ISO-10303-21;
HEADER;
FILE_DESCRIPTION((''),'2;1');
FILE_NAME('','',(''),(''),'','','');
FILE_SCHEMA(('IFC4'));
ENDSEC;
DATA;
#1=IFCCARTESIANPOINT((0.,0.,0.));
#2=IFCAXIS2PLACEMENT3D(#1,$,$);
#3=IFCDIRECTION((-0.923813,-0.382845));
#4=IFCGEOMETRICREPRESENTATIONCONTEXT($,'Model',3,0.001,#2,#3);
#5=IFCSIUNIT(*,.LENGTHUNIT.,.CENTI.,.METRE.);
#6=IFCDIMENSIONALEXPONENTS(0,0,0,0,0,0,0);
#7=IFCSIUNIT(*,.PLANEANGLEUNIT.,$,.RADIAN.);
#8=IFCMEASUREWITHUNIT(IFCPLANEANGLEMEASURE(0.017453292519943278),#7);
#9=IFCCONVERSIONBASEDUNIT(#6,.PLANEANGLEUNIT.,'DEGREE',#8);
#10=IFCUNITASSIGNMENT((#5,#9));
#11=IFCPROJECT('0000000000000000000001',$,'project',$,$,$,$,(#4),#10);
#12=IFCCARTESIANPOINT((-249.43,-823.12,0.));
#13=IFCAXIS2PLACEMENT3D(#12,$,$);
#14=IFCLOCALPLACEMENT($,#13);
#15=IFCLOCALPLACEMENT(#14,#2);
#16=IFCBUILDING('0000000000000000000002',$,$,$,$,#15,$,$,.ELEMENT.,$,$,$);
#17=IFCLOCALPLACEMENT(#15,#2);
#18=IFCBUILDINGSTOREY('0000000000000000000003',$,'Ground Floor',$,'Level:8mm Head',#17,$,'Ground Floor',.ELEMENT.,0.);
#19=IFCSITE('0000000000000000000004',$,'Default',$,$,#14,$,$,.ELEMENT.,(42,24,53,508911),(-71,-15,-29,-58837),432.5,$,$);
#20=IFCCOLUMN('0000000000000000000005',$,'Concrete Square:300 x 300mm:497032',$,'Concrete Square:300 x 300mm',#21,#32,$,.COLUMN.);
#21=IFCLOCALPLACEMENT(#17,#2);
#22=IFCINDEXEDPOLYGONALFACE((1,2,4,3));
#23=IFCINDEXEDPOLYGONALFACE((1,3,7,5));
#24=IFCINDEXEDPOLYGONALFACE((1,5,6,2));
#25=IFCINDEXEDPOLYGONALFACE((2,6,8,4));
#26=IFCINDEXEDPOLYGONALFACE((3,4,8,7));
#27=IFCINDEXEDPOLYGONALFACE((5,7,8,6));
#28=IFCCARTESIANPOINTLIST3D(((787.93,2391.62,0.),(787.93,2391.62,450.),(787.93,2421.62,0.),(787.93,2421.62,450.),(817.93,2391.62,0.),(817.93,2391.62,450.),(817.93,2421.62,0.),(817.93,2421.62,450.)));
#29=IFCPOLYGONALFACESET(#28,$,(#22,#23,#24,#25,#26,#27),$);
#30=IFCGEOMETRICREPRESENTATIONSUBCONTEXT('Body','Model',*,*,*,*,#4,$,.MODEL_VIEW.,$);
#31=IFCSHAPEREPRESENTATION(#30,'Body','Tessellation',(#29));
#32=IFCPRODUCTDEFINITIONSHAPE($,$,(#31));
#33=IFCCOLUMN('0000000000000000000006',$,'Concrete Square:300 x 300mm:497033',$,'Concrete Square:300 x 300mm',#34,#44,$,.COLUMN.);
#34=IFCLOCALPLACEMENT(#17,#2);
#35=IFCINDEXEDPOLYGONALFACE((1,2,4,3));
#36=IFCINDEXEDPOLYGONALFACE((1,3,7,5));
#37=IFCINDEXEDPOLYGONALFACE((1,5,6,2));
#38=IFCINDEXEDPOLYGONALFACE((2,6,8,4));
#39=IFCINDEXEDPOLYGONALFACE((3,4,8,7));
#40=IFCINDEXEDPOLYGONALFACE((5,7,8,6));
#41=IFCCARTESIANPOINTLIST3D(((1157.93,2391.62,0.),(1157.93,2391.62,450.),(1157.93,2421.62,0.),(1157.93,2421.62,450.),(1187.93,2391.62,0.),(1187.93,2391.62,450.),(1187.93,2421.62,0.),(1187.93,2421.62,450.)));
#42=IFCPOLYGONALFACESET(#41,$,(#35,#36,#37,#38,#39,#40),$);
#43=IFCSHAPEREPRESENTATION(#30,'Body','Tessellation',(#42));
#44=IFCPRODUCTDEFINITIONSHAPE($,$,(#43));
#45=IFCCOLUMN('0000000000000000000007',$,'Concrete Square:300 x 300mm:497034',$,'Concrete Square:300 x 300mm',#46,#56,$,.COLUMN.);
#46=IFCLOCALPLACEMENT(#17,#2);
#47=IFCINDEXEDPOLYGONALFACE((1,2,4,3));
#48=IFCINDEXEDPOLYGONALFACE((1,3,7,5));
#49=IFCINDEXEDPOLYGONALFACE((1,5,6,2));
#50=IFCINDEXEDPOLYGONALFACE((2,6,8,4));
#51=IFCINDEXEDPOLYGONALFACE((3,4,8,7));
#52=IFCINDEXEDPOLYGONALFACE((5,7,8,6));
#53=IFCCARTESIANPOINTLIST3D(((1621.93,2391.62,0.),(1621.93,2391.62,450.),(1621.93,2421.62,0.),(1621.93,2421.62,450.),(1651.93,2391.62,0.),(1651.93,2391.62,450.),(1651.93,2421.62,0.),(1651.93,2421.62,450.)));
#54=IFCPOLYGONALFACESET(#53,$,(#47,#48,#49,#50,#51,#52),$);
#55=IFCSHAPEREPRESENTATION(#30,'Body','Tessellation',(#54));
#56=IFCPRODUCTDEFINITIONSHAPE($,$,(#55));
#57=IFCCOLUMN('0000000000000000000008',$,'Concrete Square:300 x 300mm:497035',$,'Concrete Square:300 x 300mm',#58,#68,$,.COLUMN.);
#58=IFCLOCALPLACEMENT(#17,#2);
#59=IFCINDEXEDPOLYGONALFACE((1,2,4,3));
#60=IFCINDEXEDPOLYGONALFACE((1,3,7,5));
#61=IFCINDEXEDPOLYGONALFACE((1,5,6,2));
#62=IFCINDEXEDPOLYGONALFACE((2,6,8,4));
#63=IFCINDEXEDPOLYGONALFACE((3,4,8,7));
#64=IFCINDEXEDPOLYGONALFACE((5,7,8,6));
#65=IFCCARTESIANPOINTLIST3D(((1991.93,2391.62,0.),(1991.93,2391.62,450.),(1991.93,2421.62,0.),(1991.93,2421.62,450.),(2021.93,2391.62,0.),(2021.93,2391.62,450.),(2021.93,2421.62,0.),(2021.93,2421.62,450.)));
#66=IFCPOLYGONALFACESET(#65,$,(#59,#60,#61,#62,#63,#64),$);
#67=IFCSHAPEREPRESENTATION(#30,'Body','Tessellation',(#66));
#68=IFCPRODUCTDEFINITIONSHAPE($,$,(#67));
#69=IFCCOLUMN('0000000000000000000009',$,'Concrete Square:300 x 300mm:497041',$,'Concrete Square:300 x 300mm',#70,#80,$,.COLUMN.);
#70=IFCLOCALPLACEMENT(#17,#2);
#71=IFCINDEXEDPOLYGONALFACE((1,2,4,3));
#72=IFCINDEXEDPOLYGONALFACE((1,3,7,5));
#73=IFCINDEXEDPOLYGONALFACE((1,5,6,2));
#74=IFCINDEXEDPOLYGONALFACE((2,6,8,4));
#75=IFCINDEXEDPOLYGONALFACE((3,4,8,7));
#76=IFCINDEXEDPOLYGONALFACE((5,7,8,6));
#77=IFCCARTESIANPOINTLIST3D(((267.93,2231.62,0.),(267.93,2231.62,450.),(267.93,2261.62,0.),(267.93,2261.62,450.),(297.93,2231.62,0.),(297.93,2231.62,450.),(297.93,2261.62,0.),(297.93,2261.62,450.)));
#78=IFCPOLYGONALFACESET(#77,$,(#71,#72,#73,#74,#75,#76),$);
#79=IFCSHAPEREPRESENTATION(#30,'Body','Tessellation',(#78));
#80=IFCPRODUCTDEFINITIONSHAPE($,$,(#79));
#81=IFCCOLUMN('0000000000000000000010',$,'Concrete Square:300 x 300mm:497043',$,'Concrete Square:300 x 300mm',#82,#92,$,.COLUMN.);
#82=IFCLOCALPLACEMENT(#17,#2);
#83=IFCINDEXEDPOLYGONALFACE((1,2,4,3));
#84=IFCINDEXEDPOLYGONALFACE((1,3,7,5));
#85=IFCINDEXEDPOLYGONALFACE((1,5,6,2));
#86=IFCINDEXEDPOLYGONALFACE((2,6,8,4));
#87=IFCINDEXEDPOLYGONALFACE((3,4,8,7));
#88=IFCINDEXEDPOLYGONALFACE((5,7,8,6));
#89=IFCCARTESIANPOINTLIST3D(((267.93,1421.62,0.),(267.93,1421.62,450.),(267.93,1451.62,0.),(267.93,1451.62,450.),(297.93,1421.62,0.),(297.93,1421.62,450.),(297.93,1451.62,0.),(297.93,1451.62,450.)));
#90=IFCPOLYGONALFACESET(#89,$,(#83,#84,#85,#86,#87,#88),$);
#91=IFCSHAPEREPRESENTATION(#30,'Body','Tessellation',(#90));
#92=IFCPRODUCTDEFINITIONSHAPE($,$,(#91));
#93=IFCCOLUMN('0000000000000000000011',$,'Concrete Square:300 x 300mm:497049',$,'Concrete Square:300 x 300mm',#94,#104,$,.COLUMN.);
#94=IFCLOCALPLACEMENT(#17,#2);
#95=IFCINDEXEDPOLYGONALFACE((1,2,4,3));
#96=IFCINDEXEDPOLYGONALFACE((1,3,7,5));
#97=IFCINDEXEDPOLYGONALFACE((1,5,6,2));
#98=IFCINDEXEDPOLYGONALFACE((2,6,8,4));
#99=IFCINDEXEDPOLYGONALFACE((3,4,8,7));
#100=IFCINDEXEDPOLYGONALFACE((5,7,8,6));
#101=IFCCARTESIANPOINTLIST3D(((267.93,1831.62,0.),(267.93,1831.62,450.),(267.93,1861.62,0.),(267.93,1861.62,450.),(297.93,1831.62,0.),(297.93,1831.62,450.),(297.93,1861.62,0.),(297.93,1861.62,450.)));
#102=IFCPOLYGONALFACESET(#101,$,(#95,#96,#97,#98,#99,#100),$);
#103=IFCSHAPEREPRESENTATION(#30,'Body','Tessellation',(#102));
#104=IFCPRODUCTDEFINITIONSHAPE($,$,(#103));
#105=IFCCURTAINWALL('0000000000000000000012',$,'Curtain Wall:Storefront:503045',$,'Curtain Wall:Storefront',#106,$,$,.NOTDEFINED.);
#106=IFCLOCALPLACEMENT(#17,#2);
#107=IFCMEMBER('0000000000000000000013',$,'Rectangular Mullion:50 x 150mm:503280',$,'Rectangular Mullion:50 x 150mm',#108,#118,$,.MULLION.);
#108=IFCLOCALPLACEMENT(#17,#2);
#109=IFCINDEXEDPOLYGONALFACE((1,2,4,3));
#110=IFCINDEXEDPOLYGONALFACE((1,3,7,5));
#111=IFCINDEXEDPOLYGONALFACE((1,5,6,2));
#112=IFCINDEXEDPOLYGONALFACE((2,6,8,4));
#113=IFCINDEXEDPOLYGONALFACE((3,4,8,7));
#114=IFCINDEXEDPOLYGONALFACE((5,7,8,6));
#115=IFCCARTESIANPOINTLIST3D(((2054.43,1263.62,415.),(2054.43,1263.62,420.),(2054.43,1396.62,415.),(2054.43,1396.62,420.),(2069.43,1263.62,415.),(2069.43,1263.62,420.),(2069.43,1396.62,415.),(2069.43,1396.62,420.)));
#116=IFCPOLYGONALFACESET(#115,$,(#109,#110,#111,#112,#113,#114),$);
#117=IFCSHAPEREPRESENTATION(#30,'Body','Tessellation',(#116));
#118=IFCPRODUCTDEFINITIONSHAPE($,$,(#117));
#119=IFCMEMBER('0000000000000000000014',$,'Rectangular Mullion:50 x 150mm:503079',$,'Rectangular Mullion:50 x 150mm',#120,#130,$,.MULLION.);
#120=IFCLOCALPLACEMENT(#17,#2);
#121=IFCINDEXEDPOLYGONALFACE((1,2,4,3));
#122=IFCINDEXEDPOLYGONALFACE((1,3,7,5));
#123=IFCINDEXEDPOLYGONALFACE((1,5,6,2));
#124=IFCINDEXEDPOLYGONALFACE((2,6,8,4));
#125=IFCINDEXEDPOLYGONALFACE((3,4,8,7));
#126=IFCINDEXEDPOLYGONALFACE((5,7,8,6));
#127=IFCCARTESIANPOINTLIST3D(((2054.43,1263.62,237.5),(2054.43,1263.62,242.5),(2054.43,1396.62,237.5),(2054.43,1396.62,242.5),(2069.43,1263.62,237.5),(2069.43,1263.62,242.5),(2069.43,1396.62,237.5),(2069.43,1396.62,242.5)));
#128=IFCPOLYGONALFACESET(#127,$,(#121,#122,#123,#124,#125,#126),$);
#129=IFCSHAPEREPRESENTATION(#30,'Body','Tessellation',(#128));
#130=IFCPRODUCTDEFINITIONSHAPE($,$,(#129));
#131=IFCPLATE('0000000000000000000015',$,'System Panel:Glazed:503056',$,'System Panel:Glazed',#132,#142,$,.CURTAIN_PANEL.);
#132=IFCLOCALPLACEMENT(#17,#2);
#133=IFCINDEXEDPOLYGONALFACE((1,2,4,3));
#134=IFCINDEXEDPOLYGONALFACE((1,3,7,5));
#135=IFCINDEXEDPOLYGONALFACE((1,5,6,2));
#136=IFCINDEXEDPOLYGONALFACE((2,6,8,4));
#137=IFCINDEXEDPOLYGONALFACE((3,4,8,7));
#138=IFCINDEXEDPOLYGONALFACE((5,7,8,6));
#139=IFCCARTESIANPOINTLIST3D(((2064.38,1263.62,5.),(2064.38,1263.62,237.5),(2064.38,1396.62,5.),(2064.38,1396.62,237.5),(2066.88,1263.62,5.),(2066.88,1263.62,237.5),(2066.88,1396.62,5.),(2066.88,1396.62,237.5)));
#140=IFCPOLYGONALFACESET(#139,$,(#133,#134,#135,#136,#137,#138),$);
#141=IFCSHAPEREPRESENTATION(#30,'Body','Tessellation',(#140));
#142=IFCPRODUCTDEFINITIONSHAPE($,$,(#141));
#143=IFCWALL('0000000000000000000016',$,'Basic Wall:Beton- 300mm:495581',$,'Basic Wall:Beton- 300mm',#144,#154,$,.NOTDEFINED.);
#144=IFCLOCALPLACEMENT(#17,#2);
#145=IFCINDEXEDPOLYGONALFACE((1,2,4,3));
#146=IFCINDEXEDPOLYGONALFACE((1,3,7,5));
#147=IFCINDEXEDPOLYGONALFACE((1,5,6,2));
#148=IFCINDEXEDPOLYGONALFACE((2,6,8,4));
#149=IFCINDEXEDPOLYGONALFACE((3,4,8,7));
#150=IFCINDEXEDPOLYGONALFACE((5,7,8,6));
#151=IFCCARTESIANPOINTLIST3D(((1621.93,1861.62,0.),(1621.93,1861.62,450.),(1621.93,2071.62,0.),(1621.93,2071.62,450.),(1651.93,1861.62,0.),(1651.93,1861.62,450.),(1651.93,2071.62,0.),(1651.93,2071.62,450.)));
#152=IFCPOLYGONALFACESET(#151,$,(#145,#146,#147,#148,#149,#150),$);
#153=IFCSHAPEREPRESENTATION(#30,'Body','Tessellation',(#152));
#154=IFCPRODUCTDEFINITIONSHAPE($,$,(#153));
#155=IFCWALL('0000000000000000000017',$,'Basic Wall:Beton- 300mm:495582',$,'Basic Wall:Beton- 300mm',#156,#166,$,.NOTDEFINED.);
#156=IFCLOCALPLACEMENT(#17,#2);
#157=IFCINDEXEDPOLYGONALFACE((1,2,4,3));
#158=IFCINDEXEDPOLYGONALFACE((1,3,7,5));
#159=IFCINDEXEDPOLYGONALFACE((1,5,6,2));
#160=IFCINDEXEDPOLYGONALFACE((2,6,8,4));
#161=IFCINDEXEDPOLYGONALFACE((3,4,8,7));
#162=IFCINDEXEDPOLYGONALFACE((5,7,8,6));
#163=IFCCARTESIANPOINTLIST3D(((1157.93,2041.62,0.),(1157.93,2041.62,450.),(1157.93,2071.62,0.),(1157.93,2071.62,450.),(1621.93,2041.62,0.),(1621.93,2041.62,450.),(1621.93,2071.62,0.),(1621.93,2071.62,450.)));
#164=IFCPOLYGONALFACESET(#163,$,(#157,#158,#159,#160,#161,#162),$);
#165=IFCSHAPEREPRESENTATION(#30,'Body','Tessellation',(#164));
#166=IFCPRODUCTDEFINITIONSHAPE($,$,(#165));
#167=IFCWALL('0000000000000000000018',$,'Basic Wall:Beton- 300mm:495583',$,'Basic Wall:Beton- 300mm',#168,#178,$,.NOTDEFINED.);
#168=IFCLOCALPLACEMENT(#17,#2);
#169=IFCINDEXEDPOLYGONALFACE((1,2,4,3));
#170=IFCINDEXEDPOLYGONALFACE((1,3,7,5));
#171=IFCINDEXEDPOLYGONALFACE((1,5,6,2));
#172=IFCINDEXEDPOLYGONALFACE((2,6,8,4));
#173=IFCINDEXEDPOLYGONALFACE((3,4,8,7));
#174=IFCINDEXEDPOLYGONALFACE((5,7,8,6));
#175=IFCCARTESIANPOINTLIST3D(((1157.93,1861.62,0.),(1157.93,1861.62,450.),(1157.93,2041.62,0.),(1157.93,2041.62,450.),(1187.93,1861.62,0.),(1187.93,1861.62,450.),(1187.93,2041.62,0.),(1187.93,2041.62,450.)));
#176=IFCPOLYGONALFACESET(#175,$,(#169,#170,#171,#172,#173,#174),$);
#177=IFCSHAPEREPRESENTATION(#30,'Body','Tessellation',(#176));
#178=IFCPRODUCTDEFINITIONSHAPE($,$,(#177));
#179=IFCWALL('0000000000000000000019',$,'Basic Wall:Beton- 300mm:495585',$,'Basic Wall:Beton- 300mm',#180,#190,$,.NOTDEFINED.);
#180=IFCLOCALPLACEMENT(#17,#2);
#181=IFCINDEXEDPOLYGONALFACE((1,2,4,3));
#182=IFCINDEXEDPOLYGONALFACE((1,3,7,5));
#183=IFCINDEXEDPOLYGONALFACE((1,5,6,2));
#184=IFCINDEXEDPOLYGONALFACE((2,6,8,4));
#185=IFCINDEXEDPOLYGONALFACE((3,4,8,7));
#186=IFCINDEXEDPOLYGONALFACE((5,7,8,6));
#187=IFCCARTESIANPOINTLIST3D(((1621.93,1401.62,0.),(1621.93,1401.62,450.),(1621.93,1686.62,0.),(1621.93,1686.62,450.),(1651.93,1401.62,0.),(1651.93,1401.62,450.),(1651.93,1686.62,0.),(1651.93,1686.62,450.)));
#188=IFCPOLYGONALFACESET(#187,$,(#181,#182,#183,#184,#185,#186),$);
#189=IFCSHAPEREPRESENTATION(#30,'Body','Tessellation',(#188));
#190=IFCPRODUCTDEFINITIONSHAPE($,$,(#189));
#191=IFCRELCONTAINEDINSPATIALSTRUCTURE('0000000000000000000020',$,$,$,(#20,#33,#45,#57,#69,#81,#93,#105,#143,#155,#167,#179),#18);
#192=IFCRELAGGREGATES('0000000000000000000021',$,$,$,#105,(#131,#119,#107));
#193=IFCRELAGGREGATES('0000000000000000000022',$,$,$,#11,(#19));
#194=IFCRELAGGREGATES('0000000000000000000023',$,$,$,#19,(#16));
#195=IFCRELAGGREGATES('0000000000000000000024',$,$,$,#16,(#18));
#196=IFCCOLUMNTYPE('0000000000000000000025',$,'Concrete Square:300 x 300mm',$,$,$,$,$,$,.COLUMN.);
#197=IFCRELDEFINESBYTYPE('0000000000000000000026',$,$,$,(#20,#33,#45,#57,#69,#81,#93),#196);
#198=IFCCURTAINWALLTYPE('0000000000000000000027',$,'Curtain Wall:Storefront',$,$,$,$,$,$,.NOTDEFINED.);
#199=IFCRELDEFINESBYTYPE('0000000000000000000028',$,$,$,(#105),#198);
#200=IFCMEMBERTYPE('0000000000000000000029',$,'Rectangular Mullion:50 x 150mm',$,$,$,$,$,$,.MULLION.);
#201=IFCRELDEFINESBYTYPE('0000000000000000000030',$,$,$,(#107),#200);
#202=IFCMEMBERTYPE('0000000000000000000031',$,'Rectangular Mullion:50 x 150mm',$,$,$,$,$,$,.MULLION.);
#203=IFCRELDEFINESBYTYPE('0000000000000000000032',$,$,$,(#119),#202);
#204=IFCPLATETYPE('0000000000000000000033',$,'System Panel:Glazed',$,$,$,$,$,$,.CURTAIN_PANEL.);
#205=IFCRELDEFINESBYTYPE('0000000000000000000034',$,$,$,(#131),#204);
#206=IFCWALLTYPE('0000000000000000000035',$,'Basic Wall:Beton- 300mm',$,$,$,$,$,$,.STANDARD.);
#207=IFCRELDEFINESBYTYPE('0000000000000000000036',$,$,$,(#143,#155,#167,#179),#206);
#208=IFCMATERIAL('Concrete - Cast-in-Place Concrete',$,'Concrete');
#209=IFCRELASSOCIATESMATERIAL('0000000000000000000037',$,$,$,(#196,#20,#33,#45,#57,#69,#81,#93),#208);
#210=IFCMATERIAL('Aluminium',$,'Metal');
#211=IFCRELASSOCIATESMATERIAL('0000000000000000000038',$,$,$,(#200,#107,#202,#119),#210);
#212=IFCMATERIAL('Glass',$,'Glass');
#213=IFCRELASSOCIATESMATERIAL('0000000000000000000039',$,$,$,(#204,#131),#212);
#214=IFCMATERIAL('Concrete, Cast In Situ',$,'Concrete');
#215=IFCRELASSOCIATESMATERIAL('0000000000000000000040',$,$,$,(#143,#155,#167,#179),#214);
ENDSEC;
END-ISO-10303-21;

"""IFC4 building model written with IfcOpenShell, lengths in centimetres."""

from ifc_helpers import new_model, entity, si_unit, converted_unit, direction, frame, origin, place, context, subcontext, project, spatial, indexed_curve, outline, extrude, source, transform, mapped, material, type_object, type_shapes, element, aggregate, save


model = new_model("IFC4")

# Units and contexts
model_context = context("Model", 3, precision=0.001, world=origin(), true_north=direction((-0.923813, -0.382845)))
body_context = subcontext(model_context, "Body", "Model", "MODEL_VIEW")
ifc_project = project(units=[si_unit("LENGTHUNIT", "METRE", prefix="CENTI"), converted_unit("PLANEANGLEUNIT", "DEGREE", entity("IfcPlaneAngleMeasure", 0.017453292519943278), si_unit("PLANEANGLEUNIT", "RADIAN"), dimensions=[0, 0, 0, 0, 0, 0, 0])], contexts=[model_context])

# Site, building, storey
site_placement = place(None, frame((-249.43, -823.12, 0.0)))
site = spatial("IfcSite", under=ifc_project, at=site_placement, Name="Default", CompositionType="ELEMENT", RefLatitude=(42, 24, 53, 508911), RefLongitude=(-71, -15, -29, -58837), RefElevation=432.5)
building_placement = place(site_placement, origin())
building = spatial("IfcBuilding", under=site, at=building_placement, CompositionType="ELEMENT")
storey_placement = place(building_placement, origin())
storey = spatial("IfcBuildingStorey", under=building, at=storey_placement, Name="Ground Floor", ObjectType="Level:8mm Head", LongName="Ground Floor", CompositionType="ELEMENT", Elevation=0.0)

# Columns
ifc_material_1 = material(Name="Concrete - Cast-in-Place Concrete", Category="Concrete")
column_type = type_object("IfcColumnType", Name="Concrete Square:300 x 300mm", PredefinedType="COLUMN", material=ifc_material_1)
shared_shape_1 = source(origin(), body_context, "Body", "SweptSolid", [
    extrude(outline(indexed_curve([(-15.0, -15.0), (15.0, -15.0), (15.0, 15.0), (-15.0, 15.0), (-15.0, -15.0)], self_intersect=False)), frame((0.0, 0.0, 0.0), z_axis=(0.0, 0.0, 1.0), x_axis=(-1.0, 0.0, 0.0)), (0.0, 0.0, 1.0), 450.0),
])
type_shapes(column_type, [shared_shape_1])
for number, where, name in (
    (1, (802.93, 2406.62, 0.0), "Concrete Square:300 x 300mm:497032"),
    (2, (1172.93, 2406.62, 0.0), "Concrete Square:300 x 300mm:497033"),
    (3, (1636.93, 2406.62, 0.0), "Concrete Square:300 x 300mm:497034"),
    (4, (2006.93, 2406.62, 0.0), "Concrete Square:300 x 300mm:497035"),
    (5, (282.93, 2246.62, 0.0), "Concrete Square:300 x 300mm:497041"),
    (6, (282.93, 1436.62, 0.0), "Concrete Square:300 x 300mm:497043"),
    (7, (282.93, 1846.62, 0.0), "Concrete Square:300 x 300mm:497049"),
):
    element("IfcColumn", number, at=place(storey_placement, frame(where)), inside=storey, type_object=column_type, material=ifc_material_1, Name=name, ObjectType="Concrete Square:300 x 300mm", PredefinedType="COLUMN", context=body_context, shape_type="MappedRepresentation", body=[
        mapped(shared_shape_1, transform((0.0, 0.0, 0.0), scale=1.0)),
    ])

# Curtain wall, members, plate
curtain_wall_type = type_object("IfcCurtainWallType", Name="Curtain Wall:Storefront", PredefinedType="NOTDEFINED")
curtain_wall_placement = place(storey_placement, origin())
curtain_wall = element("IfcCurtainWall", 8, at=curtain_wall_placement, inside=storey, type_object=curtain_wall_type, Name="Curtain Wall:Storefront:503045", ObjectType="Curtain Wall:Storefront", PredefinedType="NOTDEFINED")
ifc_material_2 = material(Name="Aluminium", Category="Metal")
member_type_1 = type_object("IfcMemberType", Name="Rectangular Mullion:50 x 150mm", PredefinedType="MULLION", material=ifc_material_2)
shared_shape_2 = source(origin(), body_context, "Body", "SweptSolid", [
    extrude(outline(indexed_curve([(-2.5, -7.5), (2.5, -7.5), (2.5, 7.5), (-2.5, 7.5), (-2.5, -7.5)], self_intersect=False)), frame((-2.5, 0.0, -133.0), z_axis=(0.0, 0.0, 1.0), x_axis=(-1.0, 0.0, 0.0)), (0.0, 0.0, 1.0), 133.0),
])
type_shapes(member_type_1, [shared_shape_2])
member_1_placement = place(curtain_wall_placement, frame((2061.93, 1263.62, 420.0), z_axis=(0.0, -1.0, 0.0), x_axis=(0.0, 0.0, 1.0)))
member_1 = element("IfcMember", 9, at=member_1_placement, type_object=member_type_1, material=ifc_material_2, Name="Rectangular Mullion:50 x 150mm:503280", ObjectType="Rectangular Mullion:50 x 150mm", PredefinedType="MULLION", context=body_context, shape_type="MappedRepresentation", body=[
    mapped(shared_shape_2, transform((0.0, 0.0, 0.0), scale=1.0)),
])
member_type_2 = type_object("IfcMemberType", Name="Rectangular Mullion:50 x 150mm", PredefinedType="MULLION", material=ifc_material_2)
shared_shape_3 = source(origin(), body_context, "Body", "SweptSolid", [
    extrude(outline(indexed_curve([(-2.5, -7.5), (2.5, -7.5), (2.5, 7.5), (-2.5, 7.5), (-2.5, -7.5)], self_intersect=False)), frame((0.0, 0.0, -133.0), z_axis=(0.0, 0.0, 1.0), x_axis=(-1.0, 0.0, 0.0)), (0.0, 0.0, 1.0), 133.0),
])
type_shapes(member_type_2, [shared_shape_3])
member_2_placement = place(curtain_wall_placement, frame((2061.93, 1263.62, 240.0), z_axis=(0.0, -1.0, 0.0), x_axis=(0.0, 0.0, 1.0)))
member_2 = element("IfcMember", 10, at=member_2_placement, type_object=member_type_2, material=ifc_material_2, Name="Rectangular Mullion:50 x 150mm:503079", ObjectType="Rectangular Mullion:50 x 150mm", PredefinedType="MULLION", context=body_context, shape_type="MappedRepresentation", body=[
    mapped(shared_shape_3, transform((0.0, 0.0, 0.0), scale=1.0)),
])
ifc_material_3 = material(Name="Glass", Category="Glass")
plate_type = type_object("IfcPlateType", Name="System Panel:Glazed", PredefinedType="CURTAIN_PANEL", material=ifc_material_3)
shared_shape_4 = source(origin(), body_context, "Body", "SweptSolid", [
    extrude(outline(indexed_curve([(-1.25, -66.5), (1.25, -66.5), (1.25, 66.5), (-1.25, 66.5), (-1.25, -66.5)], self_intersect=False)), frame((0.0, 3.7, 0.0), z_axis=(0.0, 0.0, 1.0), x_axis=(0.0, 1.0, 0.0)), (0.0, 0.0, 1.0), 232.5),
])
type_shapes(plate_type, [shared_shape_4])
plate_placement = place(curtain_wall_placement, frame((2061.93, 1330.12, 5.0), z_axis=(0.0, 0.0, 1.0), x_axis=(0.0, -1.0, 0.0)))
plate = element("IfcPlate", 11, at=plate_placement, type_object=plate_type, material=ifc_material_3, Name="System Panel:Glazed:503056", ObjectType="System Panel:Glazed", PredefinedType="CURTAIN_PANEL", context=body_context, shape_type="MappedRepresentation", body=[
    mapped(shared_shape_4, transform((0.0, 0.0, 0.0), scale=1.0)),
])
aggregate(curtain_wall, [plate, member_2, member_1])

# Walls
ifc_material_4 = material(Name="Concrete, Cast In Situ", Category="Concrete")
wall_type_1 = type_object("IfcWallType", Name="Basic Wall:Beton- 300mm", PredefinedType="STANDARD")
wall_1_placement = place(storey_placement, frame((1636.93, 1861.62, 0.0), z_axis=(0.0, 0.0, 1.0), x_axis=(0.0, 1.0, 0.0)))
element("IfcWall", 12, at=wall_1_placement, inside=storey, type_object=wall_type_1, material=ifc_material_4, Name="Basic Wall:Beton- 300mm:495581", ObjectType="Basic Wall:Beton- 300mm", PredefinedType="NOTDEFINED", context=body_context, shape_type="SweptSolid", body=[
    extrude(outline(indexed_curve([(210.0, 15.0), (0.0, 15.0), (0.0, -15.0), (210.0, -15.0), (210.0, 15.0)], self_intersect=False)), origin(), (0.0, 0.0, 1.0), 450.0),
])
wall_2_placement = place(storey_placement, frame((1621.93, 2056.62, 0.0), z_axis=(0.0, 0.0, 1.0), x_axis=(-1.0, 0.0, 0.0)))
element("IfcWall", 13, at=wall_2_placement, inside=storey, type_object=wall_type_1, material=ifc_material_4, Name="Basic Wall:Beton- 300mm:495582", ObjectType="Basic Wall:Beton- 300mm", PredefinedType="NOTDEFINED", context=body_context, shape_type="SweptSolid", body=[
    extrude(outline(indexed_curve([(464.0, 15.0), (0.0, 15.0), (0.0, -15.0), (464.0, -15.0), (464.0, 15.0)], self_intersect=False)), origin(), (0.0, 0.0, 1.0), 450.0),
])
wall_3_placement = place(storey_placement, frame((1172.93, 2041.62, 0.0), z_axis=(0.0, 0.0, 1.0), x_axis=(0.0, -1.0, 0.0)))
element("IfcWall", 14, at=wall_3_placement, inside=storey, type_object=wall_type_1, material=ifc_material_4, Name="Basic Wall:Beton- 300mm:495583", ObjectType="Basic Wall:Beton- 300mm", PredefinedType="NOTDEFINED", context=body_context, shape_type="SweptSolid", body=[
    extrude(outline(indexed_curve([(180.0, 15.0), (0.0, 15.0), (0.0, -15.0), (180.0, -15.0), (180.0, 15.0)], self_intersect=False)), origin(), (0.0, 0.0, 1.0), 450.0),
])
wall_4_placement = place(storey_placement, frame((1636.93, 1401.62, 0.0), z_axis=(0.0, 0.0, 1.0), x_axis=(0.0, 1.0, 0.0)))
element("IfcWall", 15, at=wall_4_placement, inside=storey, type_object=wall_type_1, material=ifc_material_4, Name="Basic Wall:Beton- 300mm:495585", ObjectType="Basic Wall:Beton- 300mm", PredefinedType="NOTDEFINED", context=body_context, shape_type="SweptSolid", body=[
    extrude(outline(indexed_curve([(285.0, 15.0), (0.0, 15.0), (0.0, -15.0), (285.0, -15.0), (285.0, 15.0)], self_intersect=False)), origin(), (0.0, 0.0, 1.0), 450.0),
])

save(model, "model.ifc")
